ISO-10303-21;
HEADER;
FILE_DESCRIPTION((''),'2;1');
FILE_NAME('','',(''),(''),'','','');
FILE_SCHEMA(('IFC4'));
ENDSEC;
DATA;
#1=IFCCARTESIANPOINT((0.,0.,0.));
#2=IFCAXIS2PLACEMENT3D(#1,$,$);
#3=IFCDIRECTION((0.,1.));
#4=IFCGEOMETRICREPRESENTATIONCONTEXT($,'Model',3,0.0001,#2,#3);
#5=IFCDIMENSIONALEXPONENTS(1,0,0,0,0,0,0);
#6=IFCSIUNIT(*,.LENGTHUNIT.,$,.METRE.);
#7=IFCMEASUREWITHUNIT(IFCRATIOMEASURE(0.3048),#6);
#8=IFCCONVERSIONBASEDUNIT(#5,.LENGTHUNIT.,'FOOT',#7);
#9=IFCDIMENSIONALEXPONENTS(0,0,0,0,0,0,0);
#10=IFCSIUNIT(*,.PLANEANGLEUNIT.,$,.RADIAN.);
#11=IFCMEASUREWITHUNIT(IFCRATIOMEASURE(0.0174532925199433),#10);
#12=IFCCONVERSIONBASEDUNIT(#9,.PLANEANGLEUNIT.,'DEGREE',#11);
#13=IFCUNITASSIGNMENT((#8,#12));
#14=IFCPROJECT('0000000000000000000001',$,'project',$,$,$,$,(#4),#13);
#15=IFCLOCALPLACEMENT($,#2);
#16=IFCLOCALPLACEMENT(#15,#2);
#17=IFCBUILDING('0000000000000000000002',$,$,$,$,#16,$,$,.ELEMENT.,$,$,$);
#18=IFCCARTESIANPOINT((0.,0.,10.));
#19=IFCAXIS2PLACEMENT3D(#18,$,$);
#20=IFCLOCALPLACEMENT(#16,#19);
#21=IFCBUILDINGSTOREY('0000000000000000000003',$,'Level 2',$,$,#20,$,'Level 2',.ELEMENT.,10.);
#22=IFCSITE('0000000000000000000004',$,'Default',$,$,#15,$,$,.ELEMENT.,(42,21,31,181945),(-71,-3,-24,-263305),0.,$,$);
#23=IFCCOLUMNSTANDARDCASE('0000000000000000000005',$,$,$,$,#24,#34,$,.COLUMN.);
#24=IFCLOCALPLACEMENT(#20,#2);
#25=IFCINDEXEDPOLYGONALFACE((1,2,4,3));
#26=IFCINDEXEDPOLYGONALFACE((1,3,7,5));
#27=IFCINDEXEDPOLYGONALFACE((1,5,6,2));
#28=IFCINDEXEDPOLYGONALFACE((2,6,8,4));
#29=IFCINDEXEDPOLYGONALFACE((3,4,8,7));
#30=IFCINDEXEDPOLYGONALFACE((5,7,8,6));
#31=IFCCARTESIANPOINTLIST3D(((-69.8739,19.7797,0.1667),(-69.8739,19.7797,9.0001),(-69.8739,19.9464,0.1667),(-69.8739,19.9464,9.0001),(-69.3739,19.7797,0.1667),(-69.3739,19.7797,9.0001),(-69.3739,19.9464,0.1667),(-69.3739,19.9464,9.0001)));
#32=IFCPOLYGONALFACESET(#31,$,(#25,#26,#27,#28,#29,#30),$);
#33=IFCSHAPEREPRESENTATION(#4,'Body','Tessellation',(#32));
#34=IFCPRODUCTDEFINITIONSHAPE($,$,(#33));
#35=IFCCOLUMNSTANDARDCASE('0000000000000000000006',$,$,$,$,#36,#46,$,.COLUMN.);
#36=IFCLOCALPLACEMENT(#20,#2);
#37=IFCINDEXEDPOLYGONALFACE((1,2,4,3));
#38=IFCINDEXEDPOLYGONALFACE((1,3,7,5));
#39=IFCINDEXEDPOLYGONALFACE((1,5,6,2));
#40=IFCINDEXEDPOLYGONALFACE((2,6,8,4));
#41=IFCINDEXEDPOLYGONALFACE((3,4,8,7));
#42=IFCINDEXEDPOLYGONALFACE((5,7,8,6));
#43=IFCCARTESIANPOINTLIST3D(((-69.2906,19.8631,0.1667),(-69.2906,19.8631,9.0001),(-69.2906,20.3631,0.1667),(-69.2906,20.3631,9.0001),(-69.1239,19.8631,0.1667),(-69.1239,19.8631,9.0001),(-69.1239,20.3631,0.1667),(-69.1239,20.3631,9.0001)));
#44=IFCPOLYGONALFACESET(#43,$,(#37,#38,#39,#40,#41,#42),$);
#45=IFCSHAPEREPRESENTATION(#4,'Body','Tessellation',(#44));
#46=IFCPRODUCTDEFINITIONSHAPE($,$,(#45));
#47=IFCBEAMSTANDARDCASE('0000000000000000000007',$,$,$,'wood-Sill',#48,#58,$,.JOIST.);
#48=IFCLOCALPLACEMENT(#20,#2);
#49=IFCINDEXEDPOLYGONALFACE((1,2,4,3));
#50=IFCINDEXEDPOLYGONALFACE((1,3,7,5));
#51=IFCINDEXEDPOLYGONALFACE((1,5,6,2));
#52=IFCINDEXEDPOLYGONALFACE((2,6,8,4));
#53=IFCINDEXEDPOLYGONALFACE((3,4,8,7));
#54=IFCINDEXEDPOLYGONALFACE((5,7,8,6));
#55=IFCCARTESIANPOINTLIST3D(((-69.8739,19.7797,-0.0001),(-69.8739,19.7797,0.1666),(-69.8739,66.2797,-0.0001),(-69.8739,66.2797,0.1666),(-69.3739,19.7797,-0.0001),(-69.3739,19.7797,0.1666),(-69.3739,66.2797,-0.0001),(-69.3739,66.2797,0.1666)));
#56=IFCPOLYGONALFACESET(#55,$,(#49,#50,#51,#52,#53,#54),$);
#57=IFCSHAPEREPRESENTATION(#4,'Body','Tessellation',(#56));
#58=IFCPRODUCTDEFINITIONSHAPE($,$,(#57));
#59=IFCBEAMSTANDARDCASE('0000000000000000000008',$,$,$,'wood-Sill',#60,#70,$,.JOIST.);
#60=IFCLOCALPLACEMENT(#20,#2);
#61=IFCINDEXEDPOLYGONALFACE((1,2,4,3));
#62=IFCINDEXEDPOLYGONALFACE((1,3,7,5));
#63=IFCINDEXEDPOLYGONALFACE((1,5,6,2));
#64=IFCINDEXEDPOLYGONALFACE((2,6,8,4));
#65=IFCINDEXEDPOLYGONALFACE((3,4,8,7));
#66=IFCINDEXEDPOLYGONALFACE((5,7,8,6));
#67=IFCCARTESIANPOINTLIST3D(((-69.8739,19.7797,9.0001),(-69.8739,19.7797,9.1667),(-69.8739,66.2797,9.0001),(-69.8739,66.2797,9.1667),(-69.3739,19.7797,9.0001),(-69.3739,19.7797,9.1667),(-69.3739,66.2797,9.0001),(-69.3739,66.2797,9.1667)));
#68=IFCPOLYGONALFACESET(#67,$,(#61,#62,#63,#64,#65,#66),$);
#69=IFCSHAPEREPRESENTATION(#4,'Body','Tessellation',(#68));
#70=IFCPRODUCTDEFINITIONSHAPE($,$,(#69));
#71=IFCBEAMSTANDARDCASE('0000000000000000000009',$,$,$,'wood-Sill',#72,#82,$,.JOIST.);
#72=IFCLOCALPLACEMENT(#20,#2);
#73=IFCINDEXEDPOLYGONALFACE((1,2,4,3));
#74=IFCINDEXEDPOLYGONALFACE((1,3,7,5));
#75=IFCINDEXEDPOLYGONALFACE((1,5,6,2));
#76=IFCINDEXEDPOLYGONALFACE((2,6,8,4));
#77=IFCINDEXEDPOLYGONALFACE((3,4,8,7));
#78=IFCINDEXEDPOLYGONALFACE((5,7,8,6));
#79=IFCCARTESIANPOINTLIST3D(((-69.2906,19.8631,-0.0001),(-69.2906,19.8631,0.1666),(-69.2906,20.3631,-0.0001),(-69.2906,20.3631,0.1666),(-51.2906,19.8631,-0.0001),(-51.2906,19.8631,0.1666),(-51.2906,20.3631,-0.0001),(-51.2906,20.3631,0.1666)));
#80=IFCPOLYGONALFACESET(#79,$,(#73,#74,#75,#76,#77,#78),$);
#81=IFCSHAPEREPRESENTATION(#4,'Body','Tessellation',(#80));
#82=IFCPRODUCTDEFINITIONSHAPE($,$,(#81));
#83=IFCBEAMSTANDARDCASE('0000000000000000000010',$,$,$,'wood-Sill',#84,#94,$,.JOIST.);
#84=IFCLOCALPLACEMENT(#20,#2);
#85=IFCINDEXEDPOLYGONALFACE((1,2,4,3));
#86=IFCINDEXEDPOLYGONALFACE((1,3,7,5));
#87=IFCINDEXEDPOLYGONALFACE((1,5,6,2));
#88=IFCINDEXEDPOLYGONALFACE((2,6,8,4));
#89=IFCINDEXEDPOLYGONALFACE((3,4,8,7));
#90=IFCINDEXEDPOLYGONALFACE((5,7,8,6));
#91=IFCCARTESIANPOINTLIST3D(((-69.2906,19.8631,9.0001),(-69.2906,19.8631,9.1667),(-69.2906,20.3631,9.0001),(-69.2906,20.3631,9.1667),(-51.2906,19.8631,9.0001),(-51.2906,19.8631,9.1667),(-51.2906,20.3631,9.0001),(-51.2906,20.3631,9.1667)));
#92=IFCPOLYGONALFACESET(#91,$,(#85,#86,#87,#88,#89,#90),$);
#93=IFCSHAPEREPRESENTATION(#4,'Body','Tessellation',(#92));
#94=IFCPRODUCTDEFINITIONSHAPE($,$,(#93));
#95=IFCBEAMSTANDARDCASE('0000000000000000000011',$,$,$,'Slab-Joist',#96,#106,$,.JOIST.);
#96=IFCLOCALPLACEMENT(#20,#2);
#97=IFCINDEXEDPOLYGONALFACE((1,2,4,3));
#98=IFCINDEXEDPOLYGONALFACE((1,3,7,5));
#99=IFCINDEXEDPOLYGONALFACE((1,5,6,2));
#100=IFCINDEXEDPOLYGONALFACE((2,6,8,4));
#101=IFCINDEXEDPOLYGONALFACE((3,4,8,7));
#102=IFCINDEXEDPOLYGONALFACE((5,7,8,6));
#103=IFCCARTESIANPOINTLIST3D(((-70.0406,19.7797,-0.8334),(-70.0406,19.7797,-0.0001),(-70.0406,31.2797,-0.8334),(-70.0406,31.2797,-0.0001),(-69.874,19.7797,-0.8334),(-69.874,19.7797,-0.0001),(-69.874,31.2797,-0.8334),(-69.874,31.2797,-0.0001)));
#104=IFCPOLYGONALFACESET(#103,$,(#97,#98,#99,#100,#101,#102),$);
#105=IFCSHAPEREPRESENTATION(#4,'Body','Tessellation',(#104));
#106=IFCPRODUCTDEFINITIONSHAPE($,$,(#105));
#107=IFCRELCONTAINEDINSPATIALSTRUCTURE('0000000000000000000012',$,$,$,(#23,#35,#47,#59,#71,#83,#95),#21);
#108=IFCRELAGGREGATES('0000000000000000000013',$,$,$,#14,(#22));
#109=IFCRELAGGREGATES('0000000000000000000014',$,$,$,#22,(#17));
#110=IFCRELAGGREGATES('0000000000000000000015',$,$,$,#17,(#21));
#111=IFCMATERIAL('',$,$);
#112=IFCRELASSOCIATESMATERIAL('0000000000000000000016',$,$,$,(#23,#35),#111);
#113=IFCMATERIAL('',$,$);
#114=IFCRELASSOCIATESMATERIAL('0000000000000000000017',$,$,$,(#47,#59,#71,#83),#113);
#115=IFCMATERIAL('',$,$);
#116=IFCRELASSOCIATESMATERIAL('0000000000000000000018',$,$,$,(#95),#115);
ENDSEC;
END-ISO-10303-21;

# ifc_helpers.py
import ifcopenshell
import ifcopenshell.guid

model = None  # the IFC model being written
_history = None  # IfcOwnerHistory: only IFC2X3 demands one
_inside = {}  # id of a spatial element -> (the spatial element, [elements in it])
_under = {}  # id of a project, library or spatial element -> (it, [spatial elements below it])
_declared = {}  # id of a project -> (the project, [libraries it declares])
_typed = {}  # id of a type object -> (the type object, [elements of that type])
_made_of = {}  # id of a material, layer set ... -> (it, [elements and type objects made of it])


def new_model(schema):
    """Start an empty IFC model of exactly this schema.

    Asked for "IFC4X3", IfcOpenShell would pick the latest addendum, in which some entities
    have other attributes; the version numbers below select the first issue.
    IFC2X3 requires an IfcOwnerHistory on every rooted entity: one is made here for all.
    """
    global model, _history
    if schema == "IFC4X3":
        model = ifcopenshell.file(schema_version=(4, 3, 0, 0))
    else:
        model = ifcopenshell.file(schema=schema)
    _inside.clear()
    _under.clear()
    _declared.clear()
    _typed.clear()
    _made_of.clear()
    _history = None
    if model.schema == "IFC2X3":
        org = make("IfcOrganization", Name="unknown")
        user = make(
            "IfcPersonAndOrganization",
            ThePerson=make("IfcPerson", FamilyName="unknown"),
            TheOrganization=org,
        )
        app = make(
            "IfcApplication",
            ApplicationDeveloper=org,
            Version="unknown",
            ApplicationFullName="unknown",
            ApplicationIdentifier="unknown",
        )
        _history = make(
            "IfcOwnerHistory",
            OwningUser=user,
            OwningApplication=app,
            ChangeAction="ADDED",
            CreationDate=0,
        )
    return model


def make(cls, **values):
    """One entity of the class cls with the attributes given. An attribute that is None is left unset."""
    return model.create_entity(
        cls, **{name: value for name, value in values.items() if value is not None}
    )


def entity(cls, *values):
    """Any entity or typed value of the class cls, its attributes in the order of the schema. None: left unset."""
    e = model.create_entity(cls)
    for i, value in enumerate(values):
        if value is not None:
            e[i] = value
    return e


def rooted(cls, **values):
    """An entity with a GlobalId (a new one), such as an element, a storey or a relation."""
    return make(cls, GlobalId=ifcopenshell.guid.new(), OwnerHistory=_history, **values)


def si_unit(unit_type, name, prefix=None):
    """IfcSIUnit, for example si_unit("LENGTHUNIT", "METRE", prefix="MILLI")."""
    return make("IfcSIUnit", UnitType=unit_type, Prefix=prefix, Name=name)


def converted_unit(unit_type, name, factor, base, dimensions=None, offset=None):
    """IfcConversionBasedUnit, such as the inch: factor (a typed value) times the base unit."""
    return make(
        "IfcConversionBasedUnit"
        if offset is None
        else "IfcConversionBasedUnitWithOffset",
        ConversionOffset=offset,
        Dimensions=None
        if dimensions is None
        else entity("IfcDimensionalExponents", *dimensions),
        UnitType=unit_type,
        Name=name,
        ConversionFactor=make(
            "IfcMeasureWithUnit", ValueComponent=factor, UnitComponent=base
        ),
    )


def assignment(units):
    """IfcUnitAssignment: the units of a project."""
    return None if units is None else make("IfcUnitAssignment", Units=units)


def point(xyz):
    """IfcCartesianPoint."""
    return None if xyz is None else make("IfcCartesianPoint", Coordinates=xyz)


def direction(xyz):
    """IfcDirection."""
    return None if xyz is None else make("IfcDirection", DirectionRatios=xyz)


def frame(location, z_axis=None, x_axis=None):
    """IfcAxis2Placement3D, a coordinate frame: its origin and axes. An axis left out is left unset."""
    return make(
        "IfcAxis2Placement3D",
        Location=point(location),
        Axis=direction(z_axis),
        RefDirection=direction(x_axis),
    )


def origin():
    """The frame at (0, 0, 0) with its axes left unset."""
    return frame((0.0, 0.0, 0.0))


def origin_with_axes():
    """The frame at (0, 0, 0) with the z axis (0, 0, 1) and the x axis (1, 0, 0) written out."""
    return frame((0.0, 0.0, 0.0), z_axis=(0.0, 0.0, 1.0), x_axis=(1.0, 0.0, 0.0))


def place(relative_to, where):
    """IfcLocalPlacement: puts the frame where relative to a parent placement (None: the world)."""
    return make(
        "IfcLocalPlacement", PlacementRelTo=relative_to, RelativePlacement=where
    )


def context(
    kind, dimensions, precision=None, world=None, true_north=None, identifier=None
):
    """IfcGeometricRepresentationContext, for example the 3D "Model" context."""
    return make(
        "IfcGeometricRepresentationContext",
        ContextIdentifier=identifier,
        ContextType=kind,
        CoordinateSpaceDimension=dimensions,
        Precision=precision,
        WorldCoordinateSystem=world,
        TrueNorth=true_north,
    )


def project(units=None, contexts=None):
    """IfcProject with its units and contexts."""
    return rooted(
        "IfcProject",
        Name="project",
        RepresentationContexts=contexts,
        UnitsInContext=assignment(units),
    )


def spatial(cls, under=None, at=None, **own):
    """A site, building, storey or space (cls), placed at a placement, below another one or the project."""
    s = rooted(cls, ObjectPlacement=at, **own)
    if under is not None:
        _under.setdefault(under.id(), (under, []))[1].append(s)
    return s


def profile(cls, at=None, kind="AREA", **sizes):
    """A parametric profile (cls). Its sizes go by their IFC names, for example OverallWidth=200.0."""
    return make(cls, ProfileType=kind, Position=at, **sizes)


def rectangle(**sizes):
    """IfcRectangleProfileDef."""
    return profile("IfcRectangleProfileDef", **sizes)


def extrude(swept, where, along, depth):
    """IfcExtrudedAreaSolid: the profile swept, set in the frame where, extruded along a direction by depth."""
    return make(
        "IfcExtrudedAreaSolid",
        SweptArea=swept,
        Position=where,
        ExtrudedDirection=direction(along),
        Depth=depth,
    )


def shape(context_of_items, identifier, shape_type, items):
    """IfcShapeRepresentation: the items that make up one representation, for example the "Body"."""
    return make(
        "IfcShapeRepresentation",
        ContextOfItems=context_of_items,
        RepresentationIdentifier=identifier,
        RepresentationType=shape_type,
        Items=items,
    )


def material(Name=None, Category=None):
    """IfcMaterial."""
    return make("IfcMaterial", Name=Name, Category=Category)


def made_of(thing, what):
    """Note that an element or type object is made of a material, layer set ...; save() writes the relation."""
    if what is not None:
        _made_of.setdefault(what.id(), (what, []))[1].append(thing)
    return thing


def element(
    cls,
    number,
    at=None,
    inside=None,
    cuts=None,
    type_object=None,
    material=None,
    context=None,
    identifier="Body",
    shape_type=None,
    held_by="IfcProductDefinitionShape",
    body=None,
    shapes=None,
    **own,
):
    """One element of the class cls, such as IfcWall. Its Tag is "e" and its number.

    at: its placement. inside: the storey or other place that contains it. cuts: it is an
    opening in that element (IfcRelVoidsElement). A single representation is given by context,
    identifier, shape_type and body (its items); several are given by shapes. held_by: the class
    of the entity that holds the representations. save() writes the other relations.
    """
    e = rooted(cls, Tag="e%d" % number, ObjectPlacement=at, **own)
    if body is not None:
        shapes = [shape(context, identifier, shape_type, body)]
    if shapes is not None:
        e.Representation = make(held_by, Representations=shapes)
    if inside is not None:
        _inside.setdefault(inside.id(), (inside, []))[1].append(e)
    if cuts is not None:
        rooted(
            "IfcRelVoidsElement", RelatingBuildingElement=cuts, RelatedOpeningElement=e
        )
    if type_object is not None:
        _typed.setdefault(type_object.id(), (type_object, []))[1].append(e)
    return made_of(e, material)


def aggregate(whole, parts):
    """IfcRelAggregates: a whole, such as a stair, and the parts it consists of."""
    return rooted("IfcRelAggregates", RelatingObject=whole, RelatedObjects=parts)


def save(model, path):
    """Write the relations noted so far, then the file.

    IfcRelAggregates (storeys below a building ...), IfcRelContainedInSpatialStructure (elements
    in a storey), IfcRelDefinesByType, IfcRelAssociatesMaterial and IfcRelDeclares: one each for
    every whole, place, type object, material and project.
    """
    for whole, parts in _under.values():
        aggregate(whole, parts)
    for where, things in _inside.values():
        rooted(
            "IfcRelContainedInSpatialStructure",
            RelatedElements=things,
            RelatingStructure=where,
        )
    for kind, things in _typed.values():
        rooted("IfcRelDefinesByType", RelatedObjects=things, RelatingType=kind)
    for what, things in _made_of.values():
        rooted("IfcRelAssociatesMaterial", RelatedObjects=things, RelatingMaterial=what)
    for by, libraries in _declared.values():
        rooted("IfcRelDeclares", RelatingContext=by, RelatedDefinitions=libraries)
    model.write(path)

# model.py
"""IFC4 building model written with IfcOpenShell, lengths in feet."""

from ifc_helpers import new_model, entity, si_unit, converted_unit, direction, frame, origin, origin_with_axes, place, context, project, spatial, rectangle, extrude, material, element, save


model = new_model("IFC4")

# Units and contexts
model_context = context("Model", 3, precision=0.0001, world=origin(), true_north=direction((0.0, 1.0)))
ifc_project = project(units=[converted_unit("LENGTHUNIT", "FOOT", entity("IfcRatioMeasure", 0.3048), si_unit("LENGTHUNIT", "METRE"), dimensions=[1, 0, 0, 0, 0, 0, 0]), converted_unit("PLANEANGLEUNIT", "DEGREE", entity("IfcRatioMeasure", 0.0174532925199433), si_unit("PLANEANGLEUNIT", "RADIAN"), dimensions=[0, 0, 0, 0, 0, 0, 0])], contexts=[model_context])

# Site, building, storey
site_placement = place(None, origin())
site = spatial("IfcSite", under=ifc_project, at=site_placement, Name="Default", CompositionType="ELEMENT", RefLatitude=(42, 21, 31, 181945), RefLongitude=(-71, -3, -24, -263305), RefElevation=0.0)
building_placement = place(site_placement, origin())
building = spatial("IfcBuilding", under=site, at=building_placement, CompositionType="ELEMENT")
storey_placement = place(building_placement, frame((0.0, 0.0, 10.0)))
storey = spatial("IfcBuildingStorey", under=building, at=storey_placement, Name="Level 2", LongName="Level 2", CompositionType="ELEMENT", Elevation=10.0)

# Columns
ifc_material_1 = material(Name="")
placement_1 = place(storey_placement, frame((-69.6239, 19.7797, 0.0), z_axis=(0.0, 0.0, 1.0), x_axis=(0.0, 1.0, 0.0)))
for number, where, z_axis, x_axis in (
    (1, (0.0833, 0.0, 0.1667), (0.0, 0.0, 1.0), (1.0, 0.0, 0.0)),
):
    element("IfcColumnStandardCase", number, at=place(placement_1, frame(where, z_axis=z_axis, x_axis=x_axis)), inside=storey, material=ifc_material_1, PredefinedType="COLUMN", context=model_context, shape_type="SweptSolid", body=[
        extrude(rectangle(XDim=0.1667, YDim=0.5), origin(), (0.0, 0.0, 1.0), 8.8334),
    ])
placement_2 = place(storey_placement, frame((-69.2906, 20.1131, 0.0)))
for number, where, z_axis, x_axis in (
    (2, (0.0833, 0.0, 0.1667), (0.0, 0.0, 1.0), (1.0, 0.0, 0.0)),
):
    element("IfcColumnStandardCase", number, at=place(placement_2, frame(where, z_axis=z_axis, x_axis=x_axis)), inside=storey, material=ifc_material_1, PredefinedType="COLUMN", context=model_context, shape_type="SweptSolid", body=[
        extrude(rectangle(XDim=0.1667, YDim=0.5), origin(), (0.0, 0.0, 1.0), 8.8334),
    ])

# Beams
ifc_material_2 = material(Name="")
for number, where, z_axis, x_axis in (
    (3, (0.0, 0.0, 0.0833), (1.0, 0.0, 0.0), (0.0, 0.0, 1.0)),
    (4, (0.0, 0.0, 9.0834), (1.0, 0.0, 0.0), (0.0, 0.0, 1.0)),
):
    element("IfcBeamStandardCase", number, at=place(placement_1, frame(where, z_axis=z_axis, x_axis=x_axis)), inside=storey, material=ifc_material_2, ObjectType="wood-Sill", PredefinedType="JOIST", context=model_context, shape_type="SweptSolid", body=[
        extrude(rectangle(XDim=0.1667, YDim=0.5), origin_with_axes(), (0.0, 0.0, 1.0), 46.5),
    ])
for number, where, z_axis, x_axis in (
    (5, (0.0, 0.0, 0.0833), (1.0, 0.0, 0.0), (0.0, 0.0, 1.0)),
    (6, (0.0, 0.0, 9.0834), (1.0, 0.0, 0.0), (0.0, 0.0, 1.0)),
):
    element("IfcBeamStandardCase", number, at=place(placement_2, frame(where, z_axis=z_axis, x_axis=x_axis)), inside=storey, material=ifc_material_2, ObjectType="wood-Sill", PredefinedType="JOIST", context=model_context, shape_type="SweptSolid", body=[
        extrude(rectangle(XDim=0.1667, YDim=0.5), origin_with_axes(), (0.0, 0.0, 1.0), 18.0),
    ])
ifc_material_3 = material(Name="")
placement_3 = place(storey_placement, frame((-69.9573, 19.7797, 0.0), z_axis=(0.0, 0.0, 1.0), x_axis=(1.0, 0.0, 0.0)))
beam_1_placement = place(placement_3, frame((0.0, 0.0, -0.4167), z_axis=(0.0, 1.0, 0.0), x_axis=(-1.0, 0.0, 0.0)))
element("IfcBeamStandardCase", 7, at=beam_1_placement, inside=storey, material=ifc_material_3, ObjectType="Slab-Joist", PredefinedType="JOIST", context=model_context, shape_type="SweptSolid", body=[
    extrude(rectangle(XDim=0.1667, YDim=0.8333), origin_with_axes(), (0.0, 0.0, 1.0), 11.5),
])

save(model, "model.ifc")
